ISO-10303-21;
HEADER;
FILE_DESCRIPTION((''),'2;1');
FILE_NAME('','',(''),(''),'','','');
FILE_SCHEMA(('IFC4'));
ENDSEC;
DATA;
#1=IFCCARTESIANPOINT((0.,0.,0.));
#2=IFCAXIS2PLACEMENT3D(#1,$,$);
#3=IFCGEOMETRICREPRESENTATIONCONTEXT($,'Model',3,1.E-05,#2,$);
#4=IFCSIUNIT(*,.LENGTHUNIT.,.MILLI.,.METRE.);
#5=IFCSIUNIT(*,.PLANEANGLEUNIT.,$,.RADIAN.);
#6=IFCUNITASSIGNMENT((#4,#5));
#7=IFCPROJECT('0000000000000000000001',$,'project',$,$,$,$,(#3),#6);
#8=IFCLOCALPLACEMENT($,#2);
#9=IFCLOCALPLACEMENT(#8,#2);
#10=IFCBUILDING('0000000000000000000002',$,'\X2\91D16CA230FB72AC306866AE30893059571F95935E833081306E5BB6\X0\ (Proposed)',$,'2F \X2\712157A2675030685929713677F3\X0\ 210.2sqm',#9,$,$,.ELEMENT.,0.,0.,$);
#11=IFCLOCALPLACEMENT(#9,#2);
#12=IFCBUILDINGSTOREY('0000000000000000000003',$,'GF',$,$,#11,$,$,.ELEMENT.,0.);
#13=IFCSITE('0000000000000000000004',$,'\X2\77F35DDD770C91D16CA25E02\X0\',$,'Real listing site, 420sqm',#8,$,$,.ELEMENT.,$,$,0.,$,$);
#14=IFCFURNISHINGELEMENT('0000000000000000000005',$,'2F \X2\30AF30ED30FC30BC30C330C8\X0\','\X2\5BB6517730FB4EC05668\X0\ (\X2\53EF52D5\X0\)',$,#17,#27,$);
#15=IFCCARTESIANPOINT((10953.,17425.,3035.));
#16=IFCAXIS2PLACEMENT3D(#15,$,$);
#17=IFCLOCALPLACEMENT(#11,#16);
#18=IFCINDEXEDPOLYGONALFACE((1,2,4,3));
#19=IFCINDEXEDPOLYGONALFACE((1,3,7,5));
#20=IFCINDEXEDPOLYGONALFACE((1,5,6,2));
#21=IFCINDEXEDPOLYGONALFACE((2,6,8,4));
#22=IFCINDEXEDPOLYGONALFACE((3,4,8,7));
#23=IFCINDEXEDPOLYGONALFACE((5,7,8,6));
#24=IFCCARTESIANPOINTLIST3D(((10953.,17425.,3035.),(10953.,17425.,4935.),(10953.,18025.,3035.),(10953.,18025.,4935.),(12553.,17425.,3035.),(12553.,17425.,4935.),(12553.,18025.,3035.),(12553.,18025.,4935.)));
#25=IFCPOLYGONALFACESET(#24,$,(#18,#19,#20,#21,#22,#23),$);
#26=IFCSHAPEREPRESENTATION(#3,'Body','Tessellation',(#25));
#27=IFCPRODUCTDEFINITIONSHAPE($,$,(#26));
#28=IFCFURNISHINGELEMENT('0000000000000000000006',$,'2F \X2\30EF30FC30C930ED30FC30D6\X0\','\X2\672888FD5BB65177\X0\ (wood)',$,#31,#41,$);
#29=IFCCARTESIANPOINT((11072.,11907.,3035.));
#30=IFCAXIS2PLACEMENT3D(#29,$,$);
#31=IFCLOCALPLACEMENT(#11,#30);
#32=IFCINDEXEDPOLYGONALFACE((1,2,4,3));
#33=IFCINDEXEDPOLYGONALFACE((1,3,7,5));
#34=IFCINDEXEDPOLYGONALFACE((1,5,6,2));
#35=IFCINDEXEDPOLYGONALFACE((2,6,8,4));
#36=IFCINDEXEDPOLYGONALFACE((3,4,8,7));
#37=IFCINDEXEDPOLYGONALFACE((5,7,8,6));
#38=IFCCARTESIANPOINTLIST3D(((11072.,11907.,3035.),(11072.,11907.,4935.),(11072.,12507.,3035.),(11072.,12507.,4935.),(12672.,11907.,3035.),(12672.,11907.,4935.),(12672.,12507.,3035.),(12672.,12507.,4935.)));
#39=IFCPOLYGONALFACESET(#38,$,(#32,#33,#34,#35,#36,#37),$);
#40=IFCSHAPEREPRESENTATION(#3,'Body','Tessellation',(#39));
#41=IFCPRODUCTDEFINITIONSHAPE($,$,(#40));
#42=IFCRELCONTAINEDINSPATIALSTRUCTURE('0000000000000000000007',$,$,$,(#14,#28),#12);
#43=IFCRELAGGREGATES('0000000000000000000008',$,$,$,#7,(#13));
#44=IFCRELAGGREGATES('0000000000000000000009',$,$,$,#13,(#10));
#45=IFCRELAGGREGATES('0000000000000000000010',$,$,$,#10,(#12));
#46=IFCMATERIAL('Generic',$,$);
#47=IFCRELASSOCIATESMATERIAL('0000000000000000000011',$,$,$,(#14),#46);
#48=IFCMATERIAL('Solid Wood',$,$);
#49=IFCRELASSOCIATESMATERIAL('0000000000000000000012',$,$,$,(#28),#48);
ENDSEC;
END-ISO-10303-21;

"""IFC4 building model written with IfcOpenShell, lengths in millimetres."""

from ifc_helpers import new_model, si_unit, frame, frame_2d, origin, place, context, project, spatial, rectangle, extrude, material, element, save


model = new_model("IFC4")

# Units and contexts
model_context = context("Model", 3, precision=1e-05, world=origin())
ifc_project = project(units=[si_unit("LENGTHUNIT", "METRE", prefix="MILLI"), si_unit("PLANEANGLEUNIT", "RADIAN")], contexts=[model_context])

# Site, building, storey
site_placement = place(None, origin())
site = spatial("IfcSite", under=ifc_project, at=site_placement, Name="石川県金沢市", ObjectType="Real listing site, 420sqm", CompositionType="ELEMENT", RefElevation=0.0)
building_placement = place(site_placement, origin())
building = spatial("IfcBuilding", under=site, at=building_placement, Name="金沢・犬と暮らす土間広めの家 (Proposed)", ObjectType="2F 無垢材と天然石 210.2sqm", CompositionType="ELEMENT", ElevationOfRefHeight=0.0, ElevationOfTerrain=0.0)
storey_placement = place(building_placement, origin())
storey = spatial("IfcBuildingStorey", under=building, at=storey_placement, Name="GF", CompositionType="ELEMENT", Elevation=0.0)

# Shared definitions
ifc_material_1 = material(Name="Solid Wood")

# Shared definitions
ifc_material_2 = material(Name="Generic")

# Furnishing elements
furnishing_1_placement = place(storey_placement, frame((10953.0, 17425.0, 3035.0)))
element("IfcFurnishingElement", 1, at=furnishing_1_placement, inside=storey, material=ifc_material_2, Name="2F クローゼット", Description="家具・什器 (可動)", context=model_context, shape_type="SweptSolid", body=[
    extrude(rectangle(XDim=1600.0, YDim=600.0, at=frame_2d((800.0, 300.0))), frame((10953.0, 17425.0, 3035.0)), (0.0, 0.0, 1.0), 1900.0),
])
furnishing_2_placement = place(storey_placement, frame((11072.0, 11907.0, 3035.0)))
element("IfcFurnishingElement", 2, at=furnishing_2_placement, inside=storey, material=ifc_material_1, Name="2F ワードローブ", Description="木製家具 (wood)", context=model_context, shape_type="SweptSolid", body=[
    extrude(rectangle(XDim=1600.0, YDim=600.0, at=frame_2d((800.0, 300.0))), frame((11072.0, 11907.0, 3035.0)), (0.0, 0.0, 1.0), 1900.0),
])

save(model, "model.ifc")
